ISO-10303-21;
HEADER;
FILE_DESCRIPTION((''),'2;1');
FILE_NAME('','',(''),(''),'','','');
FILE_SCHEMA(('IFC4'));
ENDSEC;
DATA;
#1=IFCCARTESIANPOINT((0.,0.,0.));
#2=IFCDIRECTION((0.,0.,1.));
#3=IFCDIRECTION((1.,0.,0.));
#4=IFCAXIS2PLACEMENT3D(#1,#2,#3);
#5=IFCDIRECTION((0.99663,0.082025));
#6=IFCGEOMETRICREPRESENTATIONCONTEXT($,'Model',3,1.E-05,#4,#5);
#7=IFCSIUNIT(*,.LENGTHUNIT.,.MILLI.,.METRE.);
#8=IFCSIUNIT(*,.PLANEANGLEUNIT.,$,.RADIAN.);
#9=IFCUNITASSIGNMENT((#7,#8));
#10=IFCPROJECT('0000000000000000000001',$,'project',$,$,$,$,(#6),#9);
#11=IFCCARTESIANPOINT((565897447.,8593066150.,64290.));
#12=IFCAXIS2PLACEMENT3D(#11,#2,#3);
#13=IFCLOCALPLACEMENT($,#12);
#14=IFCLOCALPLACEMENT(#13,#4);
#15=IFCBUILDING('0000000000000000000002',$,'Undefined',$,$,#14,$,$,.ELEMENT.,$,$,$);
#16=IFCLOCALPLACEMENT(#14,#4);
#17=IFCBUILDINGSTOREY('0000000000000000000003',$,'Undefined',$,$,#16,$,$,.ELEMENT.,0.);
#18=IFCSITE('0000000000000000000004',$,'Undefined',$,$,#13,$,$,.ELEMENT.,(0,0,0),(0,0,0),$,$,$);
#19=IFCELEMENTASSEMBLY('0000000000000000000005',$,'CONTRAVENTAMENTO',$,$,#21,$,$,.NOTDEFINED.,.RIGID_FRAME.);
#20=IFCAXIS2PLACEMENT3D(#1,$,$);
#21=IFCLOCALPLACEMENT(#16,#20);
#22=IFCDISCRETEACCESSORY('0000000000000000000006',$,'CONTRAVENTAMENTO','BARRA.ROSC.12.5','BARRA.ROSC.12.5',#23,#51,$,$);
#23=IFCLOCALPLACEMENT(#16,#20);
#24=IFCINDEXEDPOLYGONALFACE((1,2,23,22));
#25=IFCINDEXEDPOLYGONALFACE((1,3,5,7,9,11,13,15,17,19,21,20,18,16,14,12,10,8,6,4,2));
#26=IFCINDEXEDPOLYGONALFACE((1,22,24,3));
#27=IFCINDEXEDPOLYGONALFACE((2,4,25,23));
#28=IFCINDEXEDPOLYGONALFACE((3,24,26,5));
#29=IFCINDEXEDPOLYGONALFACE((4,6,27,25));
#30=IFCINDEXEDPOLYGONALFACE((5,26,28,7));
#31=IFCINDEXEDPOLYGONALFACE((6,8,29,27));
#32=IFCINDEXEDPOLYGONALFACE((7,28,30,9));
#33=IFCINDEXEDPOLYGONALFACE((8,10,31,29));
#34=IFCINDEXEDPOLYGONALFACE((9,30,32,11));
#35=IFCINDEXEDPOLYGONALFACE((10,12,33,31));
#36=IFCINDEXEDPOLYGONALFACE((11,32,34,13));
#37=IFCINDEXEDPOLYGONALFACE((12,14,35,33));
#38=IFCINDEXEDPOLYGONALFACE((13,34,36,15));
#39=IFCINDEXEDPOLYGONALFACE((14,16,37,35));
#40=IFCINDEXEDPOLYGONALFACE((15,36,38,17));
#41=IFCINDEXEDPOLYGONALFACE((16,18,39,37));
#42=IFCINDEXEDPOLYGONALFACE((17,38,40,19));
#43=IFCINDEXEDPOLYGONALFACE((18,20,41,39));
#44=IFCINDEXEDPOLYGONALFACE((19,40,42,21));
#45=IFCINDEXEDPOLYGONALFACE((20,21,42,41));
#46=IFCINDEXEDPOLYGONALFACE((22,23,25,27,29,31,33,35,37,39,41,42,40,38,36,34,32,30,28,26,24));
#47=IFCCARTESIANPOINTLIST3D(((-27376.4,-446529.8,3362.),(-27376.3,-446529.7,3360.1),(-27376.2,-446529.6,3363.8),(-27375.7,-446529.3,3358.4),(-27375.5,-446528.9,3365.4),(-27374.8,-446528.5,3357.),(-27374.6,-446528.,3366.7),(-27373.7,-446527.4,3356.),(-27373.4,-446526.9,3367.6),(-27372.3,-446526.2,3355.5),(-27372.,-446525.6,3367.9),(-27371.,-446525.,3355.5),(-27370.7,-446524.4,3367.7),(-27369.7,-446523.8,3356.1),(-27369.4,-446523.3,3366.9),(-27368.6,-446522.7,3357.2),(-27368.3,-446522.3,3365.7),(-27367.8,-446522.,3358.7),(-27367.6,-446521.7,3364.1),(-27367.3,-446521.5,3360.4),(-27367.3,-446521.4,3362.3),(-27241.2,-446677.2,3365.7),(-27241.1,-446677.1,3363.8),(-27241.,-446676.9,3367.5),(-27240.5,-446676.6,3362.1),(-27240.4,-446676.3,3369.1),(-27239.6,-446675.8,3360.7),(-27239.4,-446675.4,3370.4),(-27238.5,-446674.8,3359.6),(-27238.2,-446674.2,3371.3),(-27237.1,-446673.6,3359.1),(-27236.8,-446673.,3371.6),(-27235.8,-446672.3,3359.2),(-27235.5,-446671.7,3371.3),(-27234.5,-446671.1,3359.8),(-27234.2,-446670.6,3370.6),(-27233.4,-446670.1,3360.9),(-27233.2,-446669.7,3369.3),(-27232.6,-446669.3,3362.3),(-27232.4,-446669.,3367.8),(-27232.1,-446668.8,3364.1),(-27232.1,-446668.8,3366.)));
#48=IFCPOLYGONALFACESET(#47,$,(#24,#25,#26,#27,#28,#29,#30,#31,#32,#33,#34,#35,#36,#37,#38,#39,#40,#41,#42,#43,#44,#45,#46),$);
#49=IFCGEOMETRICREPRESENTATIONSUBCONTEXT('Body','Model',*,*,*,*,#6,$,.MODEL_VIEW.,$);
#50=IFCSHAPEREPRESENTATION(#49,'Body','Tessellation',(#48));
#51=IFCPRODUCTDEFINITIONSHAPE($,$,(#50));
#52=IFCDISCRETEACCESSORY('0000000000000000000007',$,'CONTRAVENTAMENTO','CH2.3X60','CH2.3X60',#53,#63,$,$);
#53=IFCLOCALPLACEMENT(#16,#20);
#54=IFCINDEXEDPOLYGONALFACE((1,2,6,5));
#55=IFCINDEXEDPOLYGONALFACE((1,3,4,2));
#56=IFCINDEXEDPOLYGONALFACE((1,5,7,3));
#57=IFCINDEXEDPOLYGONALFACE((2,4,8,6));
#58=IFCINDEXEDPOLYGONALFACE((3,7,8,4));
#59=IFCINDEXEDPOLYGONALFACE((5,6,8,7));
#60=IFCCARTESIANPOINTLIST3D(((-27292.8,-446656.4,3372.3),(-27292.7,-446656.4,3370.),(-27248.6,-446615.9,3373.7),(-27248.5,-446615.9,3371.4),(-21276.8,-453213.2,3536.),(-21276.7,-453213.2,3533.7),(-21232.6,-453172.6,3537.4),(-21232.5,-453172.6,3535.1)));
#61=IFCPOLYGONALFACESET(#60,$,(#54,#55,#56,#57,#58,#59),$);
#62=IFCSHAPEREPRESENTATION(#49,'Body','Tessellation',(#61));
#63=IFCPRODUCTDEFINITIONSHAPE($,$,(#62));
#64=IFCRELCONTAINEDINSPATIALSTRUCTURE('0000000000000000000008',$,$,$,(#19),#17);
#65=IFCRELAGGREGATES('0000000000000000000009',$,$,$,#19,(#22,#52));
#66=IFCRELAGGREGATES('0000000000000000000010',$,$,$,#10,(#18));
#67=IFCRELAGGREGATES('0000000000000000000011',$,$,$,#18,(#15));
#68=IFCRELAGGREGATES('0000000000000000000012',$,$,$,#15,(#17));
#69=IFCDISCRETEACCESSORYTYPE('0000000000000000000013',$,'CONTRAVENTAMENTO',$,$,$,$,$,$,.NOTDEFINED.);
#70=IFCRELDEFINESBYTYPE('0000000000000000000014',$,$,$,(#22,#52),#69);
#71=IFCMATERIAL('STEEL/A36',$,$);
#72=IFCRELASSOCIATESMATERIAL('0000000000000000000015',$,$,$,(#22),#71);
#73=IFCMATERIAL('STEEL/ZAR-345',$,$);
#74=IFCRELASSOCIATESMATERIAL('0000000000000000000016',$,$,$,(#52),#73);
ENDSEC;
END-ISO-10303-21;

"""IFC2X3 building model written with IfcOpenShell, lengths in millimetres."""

from ifc_helpers import new_model, si_unit, direction, frame, origin_with_axes, origin_2d_with_axis, place, context, subcontext, project, spatial, polyline, circle, outline, extrude, material, type_object, element, aggregate, save


model = new_model("IFC2X3")

# Units and contexts
model_context = context("Model", 3, precision=1e-05, world=origin_with_axes(), true_north=direction((0.99663, 0.082025)))
body_context = subcontext(model_context, "Body", "Model", "MODEL_VIEW")
ifc_project = project(units=[si_unit("LENGTHUNIT", "METRE", prefix="MILLI"), si_unit("PLANEANGLEUNIT", "RADIAN")], contexts=[model_context])

# Site, building, storey
site_placement = place(None, frame((565897447.0, 8593066150.0, 64290.0), z_axis=(0.0, 0.0, 1.0), x_axis=(1.0, 0.0, 0.0)))
site = spatial("IfcSite", under=ifc_project, at=site_placement, Name="Undefined", CompositionType="ELEMENT", RefLatitude=(0, 0, 0), RefLongitude=(0, 0, 0))
building_placement = place(site_placement, origin_with_axes())
building = spatial("IfcBuilding", under=site, at=building_placement, Name="Undefined", CompositionType="ELEMENT")
storey_placement = place(building_placement, origin_with_axes())
storey = spatial("IfcBuildingStorey", under=building, at=storey_placement, Name="Undefined", CompositionType="ELEMENT", Elevation=0.0)

# Shared definitions
ifc_material_1 = material(Name="STEEL/A36")

# Element assembly, discrete accessories
assembly_1_placement = place(storey_placement, origin_with_axes())
assembly_1 = element("IfcElementAssembly", 1, at=assembly_1_placement, inside=storey, Name="CONTRAVENTAMENTO", AssemblyPlace="NOTDEFINED", PredefinedType="RIGID_FRAME")
discrete_accessory_type_1 = type_object("IfcDiscreteAccessoryType", Name="CONTRAVENTAMENTO")
discrete_accessory_1_placement = place(assembly_1_placement, frame((-27371.8, -446525.6, 3361.7), z_axis=(0.736334, 0.676203, 0.02368), x_axis=(0.675958, -0.736711, 0.018398)))
discrete_accessory_1 = element("IfcDiscreteAccessory", 2, at=discrete_accessory_1_placement, type_object=discrete_accessory_type_1, material=ifc_material_1, Name="CONTRAVENTAMENTO", Description="BARRA.ROSC.12.5", ObjectType="BARRA.ROSC.12.5", context=body_context, shape_type="SweptSolid", body=[
    extrude(circle(Radius=6.2, at=origin_2d_with_axis()), frame((200.0, 0.0, 0.0), z_axis=(-1.0, 0.0, 0.0), x_axis=(0.0, -1.0, 0.0)), (0.0, 0.0, 1.0), 200.0),
])
ifc_material_2 = material(Name="STEEL/ZAR-345")
discrete_accessory_2_placement = place(assembly_1_placement, frame((-27270.7, -446636.1, 3371.8), z_axis=(-0.029885, -0.00246, 0.99955), x_axis=(0.675958, -0.736711, 0.018398)))
discrete_accessory_2 = element("IfcDiscreteAccessory", 3, at=discrete_accessory_2_placement, type_object=discrete_accessory_type_1, material=ifc_material_2, Name="CONTRAVENTAMENTO", Description="CH2.3X60", ObjectType="CH2.3X60", context=body_context, shape_type="SweptSolid", body=[
    extrude(outline(polyline([(0.0, 30.0), (8900.0, 30.0), (8900.0, -30.0), (0.0, -30.0), (0.0, 30.0)])), frame((0.0, 0.0, -1.1), z_axis=(0.0, 0.0, 1.0), x_axis=(1.0, 0.0, 0.0)), (0.0, 0.0, 1.0), 2.3),
])
aggregate(assembly_1, [discrete_accessory_1, discrete_accessory_2])

save(model, "model.ifc")
